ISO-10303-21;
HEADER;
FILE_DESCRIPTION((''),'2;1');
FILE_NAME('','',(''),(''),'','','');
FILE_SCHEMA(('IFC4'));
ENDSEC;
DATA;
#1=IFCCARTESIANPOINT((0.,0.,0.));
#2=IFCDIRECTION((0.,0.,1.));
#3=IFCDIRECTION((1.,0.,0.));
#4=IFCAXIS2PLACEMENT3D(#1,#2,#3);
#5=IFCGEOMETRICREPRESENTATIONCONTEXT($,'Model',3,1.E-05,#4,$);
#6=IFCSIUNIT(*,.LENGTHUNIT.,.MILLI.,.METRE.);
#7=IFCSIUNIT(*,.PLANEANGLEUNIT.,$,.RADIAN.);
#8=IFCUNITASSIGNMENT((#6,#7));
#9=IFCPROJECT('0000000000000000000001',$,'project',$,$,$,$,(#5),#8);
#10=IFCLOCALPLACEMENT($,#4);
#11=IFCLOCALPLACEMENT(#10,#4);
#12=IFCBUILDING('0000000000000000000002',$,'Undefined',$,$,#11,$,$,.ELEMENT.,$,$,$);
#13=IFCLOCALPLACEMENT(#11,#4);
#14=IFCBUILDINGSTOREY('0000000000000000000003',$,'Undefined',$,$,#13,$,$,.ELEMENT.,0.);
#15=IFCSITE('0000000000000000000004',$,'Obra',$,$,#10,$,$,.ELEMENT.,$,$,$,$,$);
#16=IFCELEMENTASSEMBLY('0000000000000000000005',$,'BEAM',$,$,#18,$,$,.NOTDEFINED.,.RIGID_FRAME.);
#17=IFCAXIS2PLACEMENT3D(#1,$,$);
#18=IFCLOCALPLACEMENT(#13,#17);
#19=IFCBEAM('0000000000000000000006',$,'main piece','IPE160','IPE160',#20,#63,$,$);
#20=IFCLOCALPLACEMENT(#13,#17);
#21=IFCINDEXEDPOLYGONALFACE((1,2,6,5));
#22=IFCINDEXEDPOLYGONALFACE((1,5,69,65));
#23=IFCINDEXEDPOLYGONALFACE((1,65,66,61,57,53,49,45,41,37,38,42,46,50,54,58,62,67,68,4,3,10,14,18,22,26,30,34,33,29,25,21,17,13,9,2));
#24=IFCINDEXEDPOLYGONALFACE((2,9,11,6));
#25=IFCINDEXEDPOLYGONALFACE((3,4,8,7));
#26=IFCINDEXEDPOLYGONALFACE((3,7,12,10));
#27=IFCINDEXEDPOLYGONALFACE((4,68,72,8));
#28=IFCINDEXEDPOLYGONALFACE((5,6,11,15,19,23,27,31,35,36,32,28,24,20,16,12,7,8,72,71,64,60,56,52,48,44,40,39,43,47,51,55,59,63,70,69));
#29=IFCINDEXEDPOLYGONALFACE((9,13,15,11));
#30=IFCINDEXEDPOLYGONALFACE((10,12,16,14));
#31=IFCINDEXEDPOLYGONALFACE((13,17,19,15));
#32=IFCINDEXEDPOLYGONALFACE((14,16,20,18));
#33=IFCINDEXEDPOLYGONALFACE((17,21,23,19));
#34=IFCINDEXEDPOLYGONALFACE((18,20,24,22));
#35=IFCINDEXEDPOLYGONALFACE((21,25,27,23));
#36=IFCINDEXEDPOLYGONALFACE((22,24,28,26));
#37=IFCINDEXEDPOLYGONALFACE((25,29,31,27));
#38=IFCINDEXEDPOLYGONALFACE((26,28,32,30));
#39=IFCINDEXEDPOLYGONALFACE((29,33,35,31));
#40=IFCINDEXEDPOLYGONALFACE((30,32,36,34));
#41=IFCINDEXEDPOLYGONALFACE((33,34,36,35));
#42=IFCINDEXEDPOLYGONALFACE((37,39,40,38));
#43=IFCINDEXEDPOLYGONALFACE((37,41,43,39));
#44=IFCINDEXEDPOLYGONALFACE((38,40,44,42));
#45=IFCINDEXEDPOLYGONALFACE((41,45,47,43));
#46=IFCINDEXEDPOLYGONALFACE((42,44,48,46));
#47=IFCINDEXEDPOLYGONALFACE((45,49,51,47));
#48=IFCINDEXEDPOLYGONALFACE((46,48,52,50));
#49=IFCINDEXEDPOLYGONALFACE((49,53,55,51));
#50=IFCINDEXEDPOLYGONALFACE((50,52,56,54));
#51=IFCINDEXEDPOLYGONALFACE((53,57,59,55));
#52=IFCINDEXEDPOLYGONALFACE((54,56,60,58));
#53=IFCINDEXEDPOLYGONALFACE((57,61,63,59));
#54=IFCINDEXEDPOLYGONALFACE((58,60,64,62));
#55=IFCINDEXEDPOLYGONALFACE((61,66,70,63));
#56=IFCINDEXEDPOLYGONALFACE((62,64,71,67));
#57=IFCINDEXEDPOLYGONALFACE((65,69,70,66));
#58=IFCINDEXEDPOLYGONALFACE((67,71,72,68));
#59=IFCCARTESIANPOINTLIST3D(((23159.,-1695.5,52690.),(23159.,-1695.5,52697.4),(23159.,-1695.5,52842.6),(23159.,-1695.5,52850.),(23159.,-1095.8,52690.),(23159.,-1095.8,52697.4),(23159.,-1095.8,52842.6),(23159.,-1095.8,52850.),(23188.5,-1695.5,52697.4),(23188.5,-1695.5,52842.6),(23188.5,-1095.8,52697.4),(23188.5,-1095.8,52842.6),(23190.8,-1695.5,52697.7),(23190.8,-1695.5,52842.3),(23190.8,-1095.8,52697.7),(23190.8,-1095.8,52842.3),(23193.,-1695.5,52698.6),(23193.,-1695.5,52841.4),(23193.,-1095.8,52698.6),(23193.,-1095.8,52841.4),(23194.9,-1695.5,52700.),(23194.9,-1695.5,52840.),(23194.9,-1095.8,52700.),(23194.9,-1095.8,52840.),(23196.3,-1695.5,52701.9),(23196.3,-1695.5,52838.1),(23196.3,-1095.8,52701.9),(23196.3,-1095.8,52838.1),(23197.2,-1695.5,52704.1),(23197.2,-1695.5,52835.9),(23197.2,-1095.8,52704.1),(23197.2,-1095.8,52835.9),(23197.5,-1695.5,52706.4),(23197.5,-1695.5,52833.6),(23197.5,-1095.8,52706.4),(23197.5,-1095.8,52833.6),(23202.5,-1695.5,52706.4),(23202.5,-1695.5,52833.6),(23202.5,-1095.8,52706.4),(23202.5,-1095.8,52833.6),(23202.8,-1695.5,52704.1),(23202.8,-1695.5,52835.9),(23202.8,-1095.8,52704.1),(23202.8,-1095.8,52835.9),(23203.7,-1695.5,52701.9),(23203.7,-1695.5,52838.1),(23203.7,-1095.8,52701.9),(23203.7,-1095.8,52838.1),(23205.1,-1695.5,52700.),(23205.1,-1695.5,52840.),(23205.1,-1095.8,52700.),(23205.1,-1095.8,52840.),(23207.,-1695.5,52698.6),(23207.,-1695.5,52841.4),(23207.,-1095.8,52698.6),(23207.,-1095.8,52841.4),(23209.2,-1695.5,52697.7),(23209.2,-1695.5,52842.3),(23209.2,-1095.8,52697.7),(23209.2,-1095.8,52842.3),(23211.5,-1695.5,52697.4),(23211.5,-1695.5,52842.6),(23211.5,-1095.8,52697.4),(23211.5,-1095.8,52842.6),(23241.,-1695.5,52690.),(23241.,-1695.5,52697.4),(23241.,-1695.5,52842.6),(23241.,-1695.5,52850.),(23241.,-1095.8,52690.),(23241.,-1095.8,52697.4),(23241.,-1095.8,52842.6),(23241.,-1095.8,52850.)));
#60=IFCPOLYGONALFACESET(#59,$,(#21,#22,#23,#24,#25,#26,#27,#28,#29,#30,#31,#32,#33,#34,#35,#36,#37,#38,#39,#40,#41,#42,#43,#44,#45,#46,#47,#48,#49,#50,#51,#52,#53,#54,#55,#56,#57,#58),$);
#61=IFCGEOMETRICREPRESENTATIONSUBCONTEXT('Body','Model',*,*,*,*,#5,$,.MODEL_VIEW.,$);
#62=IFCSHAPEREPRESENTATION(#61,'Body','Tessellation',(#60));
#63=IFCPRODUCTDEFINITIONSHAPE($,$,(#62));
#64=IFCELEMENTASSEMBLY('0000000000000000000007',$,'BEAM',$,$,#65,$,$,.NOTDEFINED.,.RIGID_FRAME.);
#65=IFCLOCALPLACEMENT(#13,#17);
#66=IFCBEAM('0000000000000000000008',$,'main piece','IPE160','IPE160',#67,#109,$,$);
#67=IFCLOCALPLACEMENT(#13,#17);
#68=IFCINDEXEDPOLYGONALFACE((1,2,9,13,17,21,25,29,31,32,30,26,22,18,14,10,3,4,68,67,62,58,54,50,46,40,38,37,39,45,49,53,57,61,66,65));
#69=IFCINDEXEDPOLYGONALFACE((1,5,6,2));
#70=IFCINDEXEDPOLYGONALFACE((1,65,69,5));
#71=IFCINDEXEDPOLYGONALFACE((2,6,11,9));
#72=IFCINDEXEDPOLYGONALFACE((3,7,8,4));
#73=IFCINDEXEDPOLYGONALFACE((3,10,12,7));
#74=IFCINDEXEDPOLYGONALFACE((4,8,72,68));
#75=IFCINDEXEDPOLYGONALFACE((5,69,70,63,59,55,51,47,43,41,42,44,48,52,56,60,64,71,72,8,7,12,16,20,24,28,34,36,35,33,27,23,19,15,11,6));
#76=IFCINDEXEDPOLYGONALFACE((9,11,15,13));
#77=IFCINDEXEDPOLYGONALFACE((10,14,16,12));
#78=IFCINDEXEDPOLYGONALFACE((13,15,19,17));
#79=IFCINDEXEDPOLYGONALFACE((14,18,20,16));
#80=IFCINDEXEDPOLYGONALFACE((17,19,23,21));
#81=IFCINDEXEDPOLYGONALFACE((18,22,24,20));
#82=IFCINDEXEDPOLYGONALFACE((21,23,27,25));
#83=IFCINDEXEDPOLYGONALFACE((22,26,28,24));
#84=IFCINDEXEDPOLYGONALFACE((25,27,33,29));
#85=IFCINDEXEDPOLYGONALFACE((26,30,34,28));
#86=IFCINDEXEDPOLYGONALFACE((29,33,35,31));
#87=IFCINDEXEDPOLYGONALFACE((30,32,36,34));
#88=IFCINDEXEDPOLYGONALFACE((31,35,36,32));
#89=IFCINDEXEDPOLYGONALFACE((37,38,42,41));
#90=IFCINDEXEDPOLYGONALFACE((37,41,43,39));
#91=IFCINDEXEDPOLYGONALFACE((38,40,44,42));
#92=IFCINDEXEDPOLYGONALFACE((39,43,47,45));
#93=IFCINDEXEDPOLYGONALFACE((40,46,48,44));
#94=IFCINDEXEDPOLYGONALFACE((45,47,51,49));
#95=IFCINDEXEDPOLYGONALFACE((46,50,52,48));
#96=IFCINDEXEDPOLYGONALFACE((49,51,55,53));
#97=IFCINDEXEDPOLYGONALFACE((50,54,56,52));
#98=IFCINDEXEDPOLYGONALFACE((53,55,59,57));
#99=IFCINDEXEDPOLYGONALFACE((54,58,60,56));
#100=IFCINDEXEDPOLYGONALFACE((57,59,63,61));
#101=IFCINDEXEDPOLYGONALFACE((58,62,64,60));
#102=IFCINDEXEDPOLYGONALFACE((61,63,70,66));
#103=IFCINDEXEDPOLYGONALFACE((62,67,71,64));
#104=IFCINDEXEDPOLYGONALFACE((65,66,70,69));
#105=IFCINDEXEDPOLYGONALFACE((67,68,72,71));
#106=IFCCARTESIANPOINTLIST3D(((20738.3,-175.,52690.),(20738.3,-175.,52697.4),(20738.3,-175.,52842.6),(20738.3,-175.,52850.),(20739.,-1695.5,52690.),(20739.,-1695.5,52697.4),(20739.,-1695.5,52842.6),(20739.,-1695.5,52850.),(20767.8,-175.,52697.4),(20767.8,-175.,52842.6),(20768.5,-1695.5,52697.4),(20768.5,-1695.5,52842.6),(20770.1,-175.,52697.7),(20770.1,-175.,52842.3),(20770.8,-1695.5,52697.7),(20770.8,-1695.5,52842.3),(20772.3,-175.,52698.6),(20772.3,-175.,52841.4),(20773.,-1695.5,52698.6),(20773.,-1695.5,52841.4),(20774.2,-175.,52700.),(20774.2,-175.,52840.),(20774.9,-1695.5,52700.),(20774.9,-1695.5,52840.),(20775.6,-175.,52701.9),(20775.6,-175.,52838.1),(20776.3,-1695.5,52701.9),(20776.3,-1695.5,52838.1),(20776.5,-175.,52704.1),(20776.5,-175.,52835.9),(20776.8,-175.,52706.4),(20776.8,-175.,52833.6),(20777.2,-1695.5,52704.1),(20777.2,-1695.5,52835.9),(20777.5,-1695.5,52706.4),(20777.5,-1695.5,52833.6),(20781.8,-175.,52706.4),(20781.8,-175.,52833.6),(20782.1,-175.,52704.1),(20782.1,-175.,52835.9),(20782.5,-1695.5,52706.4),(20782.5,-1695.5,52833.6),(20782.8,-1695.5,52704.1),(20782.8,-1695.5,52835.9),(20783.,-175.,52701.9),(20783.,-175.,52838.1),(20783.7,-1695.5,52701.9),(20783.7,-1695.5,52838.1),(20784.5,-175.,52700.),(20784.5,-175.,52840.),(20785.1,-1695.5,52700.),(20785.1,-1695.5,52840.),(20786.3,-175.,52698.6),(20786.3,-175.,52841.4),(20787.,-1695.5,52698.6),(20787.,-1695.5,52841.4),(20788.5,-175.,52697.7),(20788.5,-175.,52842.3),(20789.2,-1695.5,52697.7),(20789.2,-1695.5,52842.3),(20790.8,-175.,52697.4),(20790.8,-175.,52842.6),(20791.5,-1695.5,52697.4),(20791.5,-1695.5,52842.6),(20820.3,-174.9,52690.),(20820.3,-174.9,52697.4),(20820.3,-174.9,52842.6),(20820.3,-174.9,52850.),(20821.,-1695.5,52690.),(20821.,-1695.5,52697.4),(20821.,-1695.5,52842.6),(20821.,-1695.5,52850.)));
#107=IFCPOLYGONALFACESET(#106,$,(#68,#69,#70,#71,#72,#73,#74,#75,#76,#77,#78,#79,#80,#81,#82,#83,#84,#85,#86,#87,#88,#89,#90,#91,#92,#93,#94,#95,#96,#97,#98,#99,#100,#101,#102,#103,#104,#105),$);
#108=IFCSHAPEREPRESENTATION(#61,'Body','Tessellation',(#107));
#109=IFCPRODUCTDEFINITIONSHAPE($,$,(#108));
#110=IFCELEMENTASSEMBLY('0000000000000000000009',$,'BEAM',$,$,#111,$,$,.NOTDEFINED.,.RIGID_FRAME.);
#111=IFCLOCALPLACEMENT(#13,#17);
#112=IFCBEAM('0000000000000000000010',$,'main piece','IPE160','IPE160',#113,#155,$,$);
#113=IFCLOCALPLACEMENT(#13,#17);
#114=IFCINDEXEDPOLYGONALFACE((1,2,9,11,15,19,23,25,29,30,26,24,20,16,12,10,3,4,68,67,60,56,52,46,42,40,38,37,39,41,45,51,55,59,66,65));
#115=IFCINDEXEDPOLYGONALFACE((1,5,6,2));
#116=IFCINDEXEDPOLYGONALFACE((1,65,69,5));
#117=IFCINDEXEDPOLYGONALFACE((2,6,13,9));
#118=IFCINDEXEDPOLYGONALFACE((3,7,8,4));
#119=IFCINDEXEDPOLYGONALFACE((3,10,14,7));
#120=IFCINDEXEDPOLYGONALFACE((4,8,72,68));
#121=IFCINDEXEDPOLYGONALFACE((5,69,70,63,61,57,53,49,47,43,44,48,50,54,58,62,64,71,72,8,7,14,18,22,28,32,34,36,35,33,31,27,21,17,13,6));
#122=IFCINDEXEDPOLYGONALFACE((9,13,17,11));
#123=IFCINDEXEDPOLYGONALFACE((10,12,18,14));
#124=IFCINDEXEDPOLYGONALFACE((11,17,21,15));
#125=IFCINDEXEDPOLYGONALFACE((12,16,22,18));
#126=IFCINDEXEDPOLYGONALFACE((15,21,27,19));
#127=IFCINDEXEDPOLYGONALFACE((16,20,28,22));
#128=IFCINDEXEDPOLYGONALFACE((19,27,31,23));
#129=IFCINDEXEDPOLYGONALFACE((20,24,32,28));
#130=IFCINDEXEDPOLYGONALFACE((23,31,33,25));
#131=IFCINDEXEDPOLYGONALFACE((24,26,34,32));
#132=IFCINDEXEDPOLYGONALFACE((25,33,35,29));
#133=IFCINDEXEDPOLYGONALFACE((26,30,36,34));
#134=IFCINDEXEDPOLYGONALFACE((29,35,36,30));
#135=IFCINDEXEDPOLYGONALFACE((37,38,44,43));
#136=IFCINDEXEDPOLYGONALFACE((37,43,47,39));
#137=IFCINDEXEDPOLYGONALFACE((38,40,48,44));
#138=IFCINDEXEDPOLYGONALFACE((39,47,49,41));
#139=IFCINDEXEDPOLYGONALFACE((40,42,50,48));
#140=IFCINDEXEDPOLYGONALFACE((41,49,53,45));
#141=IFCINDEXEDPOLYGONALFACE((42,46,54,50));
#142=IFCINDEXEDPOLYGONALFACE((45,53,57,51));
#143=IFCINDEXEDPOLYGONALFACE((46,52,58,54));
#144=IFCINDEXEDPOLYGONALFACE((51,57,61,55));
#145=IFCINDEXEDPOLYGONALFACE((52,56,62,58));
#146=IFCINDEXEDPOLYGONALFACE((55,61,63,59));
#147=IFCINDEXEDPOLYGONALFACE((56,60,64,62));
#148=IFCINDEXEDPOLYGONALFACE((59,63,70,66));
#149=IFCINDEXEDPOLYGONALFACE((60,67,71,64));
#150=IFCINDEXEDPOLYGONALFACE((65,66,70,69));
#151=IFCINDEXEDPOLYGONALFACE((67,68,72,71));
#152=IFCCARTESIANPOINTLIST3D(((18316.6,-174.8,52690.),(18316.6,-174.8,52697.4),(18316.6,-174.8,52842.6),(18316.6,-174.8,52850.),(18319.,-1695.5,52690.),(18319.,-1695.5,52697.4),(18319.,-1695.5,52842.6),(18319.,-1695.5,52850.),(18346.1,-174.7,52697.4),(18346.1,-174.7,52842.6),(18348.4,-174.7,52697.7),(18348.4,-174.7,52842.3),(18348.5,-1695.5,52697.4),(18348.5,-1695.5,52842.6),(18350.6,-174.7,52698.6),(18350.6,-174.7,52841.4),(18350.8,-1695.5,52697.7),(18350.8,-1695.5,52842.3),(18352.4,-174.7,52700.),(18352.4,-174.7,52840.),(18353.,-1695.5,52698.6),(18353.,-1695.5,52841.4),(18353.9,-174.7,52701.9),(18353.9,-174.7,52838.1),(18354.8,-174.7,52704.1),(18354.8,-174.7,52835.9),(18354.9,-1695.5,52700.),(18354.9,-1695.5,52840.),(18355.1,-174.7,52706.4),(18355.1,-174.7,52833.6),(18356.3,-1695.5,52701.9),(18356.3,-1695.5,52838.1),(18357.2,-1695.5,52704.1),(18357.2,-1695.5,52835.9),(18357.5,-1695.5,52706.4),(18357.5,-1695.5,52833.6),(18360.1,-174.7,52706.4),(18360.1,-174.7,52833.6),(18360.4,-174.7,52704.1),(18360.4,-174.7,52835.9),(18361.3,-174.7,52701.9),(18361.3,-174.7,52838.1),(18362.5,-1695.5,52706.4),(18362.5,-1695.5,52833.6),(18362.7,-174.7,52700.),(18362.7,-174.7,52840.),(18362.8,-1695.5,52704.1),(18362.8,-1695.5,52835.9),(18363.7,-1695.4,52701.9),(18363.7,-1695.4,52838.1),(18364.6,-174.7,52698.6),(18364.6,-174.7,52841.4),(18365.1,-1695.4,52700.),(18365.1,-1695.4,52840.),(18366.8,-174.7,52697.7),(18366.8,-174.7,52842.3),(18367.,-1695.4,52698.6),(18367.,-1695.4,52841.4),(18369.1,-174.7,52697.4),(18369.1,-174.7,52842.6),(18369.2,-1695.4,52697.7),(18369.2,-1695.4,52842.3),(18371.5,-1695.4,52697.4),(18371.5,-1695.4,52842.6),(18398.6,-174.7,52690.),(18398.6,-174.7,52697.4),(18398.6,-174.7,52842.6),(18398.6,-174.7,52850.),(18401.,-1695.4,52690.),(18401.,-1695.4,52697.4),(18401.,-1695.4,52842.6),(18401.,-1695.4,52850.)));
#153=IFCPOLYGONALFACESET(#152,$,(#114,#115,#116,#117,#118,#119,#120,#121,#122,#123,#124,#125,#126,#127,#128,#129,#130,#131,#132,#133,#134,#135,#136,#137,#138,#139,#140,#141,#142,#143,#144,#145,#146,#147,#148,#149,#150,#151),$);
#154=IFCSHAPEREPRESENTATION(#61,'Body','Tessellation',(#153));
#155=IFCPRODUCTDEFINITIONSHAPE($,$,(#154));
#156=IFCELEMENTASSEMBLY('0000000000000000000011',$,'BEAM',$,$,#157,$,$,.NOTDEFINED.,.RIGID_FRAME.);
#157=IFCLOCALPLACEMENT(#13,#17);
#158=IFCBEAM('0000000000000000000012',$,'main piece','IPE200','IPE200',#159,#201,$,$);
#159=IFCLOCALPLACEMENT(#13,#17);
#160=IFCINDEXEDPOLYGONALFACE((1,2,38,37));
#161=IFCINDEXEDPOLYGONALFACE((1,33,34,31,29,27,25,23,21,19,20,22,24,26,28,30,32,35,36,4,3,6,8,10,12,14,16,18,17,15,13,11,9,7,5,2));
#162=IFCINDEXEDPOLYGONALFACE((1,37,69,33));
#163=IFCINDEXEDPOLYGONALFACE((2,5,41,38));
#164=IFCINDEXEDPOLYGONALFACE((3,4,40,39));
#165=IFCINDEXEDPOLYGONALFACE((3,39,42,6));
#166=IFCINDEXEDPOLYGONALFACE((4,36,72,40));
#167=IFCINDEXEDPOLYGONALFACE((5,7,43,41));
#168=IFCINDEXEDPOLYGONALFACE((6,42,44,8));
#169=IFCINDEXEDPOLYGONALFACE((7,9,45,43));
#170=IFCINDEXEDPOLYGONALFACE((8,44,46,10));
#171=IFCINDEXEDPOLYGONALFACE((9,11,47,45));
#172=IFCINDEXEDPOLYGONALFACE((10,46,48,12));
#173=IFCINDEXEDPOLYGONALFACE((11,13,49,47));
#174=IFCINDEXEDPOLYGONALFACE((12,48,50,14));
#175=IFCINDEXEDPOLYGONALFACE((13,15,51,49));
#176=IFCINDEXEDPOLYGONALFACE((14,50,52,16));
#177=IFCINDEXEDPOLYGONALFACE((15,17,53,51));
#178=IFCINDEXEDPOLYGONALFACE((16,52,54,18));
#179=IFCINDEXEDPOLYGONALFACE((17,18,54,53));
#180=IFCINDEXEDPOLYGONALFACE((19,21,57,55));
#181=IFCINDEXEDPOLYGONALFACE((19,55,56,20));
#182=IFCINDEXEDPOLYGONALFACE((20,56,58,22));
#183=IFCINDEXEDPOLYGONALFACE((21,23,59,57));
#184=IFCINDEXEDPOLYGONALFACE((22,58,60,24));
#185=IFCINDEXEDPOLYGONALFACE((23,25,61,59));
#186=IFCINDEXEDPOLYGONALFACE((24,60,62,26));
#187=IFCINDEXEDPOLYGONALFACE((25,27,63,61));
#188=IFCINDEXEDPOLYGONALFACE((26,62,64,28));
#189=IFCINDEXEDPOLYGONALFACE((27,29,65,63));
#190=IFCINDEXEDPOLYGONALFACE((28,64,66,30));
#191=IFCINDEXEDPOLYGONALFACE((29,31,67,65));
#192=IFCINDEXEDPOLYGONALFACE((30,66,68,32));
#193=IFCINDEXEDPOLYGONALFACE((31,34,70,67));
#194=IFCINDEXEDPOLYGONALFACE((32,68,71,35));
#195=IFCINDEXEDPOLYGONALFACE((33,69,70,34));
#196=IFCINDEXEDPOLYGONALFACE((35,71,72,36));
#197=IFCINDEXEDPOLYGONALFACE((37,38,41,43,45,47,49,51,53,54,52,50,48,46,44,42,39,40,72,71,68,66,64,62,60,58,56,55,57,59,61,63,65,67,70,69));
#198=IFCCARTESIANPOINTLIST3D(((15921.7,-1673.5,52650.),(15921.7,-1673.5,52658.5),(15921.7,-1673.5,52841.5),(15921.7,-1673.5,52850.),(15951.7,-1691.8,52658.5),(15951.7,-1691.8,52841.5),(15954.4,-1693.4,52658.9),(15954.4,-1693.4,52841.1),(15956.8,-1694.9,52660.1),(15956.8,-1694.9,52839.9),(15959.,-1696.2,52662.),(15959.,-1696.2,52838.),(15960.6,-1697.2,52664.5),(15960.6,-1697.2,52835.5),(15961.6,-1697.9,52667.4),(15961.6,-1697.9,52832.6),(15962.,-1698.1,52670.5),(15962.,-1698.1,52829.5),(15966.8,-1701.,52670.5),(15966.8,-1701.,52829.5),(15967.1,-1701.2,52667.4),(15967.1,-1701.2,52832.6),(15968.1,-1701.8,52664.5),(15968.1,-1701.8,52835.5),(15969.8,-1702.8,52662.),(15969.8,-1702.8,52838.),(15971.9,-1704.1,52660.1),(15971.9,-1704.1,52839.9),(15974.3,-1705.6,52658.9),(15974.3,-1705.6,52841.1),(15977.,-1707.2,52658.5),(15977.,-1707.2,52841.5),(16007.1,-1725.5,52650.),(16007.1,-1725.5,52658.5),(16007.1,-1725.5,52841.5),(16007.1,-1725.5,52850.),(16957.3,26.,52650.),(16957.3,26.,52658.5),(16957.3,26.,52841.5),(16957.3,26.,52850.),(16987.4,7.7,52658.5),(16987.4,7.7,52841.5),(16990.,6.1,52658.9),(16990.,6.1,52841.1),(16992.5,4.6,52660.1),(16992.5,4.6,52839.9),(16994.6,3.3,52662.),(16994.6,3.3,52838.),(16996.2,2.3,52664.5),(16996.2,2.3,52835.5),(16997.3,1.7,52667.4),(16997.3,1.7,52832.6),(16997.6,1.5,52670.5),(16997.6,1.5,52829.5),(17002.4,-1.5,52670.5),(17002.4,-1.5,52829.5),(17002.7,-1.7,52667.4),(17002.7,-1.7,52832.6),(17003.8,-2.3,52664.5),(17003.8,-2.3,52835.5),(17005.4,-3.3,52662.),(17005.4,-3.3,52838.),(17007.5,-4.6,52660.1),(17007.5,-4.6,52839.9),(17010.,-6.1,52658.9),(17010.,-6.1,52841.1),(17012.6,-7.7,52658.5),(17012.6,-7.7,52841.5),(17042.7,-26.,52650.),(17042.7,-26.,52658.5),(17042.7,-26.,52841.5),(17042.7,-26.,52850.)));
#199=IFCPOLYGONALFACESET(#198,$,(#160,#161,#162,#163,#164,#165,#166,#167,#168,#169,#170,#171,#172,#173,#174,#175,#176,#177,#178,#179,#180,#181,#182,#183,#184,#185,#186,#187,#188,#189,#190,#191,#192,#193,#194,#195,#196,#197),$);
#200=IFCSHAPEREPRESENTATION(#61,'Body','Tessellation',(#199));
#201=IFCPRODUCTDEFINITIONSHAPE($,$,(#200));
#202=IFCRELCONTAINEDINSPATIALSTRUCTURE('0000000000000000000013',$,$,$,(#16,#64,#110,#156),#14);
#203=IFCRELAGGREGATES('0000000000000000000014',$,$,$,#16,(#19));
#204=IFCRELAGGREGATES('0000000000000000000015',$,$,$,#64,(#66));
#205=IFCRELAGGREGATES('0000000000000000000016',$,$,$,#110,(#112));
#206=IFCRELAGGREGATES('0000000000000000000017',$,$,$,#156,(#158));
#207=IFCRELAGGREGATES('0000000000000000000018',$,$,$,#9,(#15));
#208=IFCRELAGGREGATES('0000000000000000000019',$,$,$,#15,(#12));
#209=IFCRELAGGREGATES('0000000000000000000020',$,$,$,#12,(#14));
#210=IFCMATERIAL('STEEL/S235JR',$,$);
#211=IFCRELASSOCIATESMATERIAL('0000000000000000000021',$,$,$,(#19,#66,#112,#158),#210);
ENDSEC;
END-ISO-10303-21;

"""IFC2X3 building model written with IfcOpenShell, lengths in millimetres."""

from ifc_helpers import new_model, si_unit, frame, origin_with_axes, origin_2d_with_axis, place, context, subcontext, project, spatial, i_section, extrude, material, element, aggregate, save


model = new_model("IFC2X3")

# Units and contexts
model_context = context("Model", 3, precision=1e-05, world=origin_with_axes())
body_context = subcontext(model_context, "Body", "Model", "MODEL_VIEW")
ifc_project = project(units=[si_unit("LENGTHUNIT", "METRE", prefix="MILLI"), si_unit("PLANEANGLEUNIT", "RADIAN")], contexts=[model_context])

# Site, building, storey
site_placement = place(None, origin_with_axes())
site = spatial("IfcSite", under=ifc_project, at=site_placement, Name="Obra", CompositionType="ELEMENT")
building_placement = place(site_placement, origin_with_axes())
building = spatial("IfcBuilding", under=site, at=building_placement, Name="Undefined", CompositionType="ELEMENT")
storey_placement = place(building_placement, origin_with_axes())
storey = spatial("IfcBuildingStorey", under=building, at=storey_placement, Name="Undefined", CompositionType="ELEMENT", Elevation=0.0)

# Shared definitions
ifc_material_1 = material(Name="STEEL/S235JR")

# Element assemblies, beams
assembly_1_placement = place(storey_placement, origin_with_axes())
assembly_1 = element("IfcElementAssembly", 1, at=assembly_1_placement, inside=storey, Name="BEAM", AssemblyPlace="NOTDEFINED", PredefinedType="RIGID_FRAME")
beam_1_placement = place(assembly_1_placement, frame((23200.0, -1695.5, 52770.0), z_axis=(0.0, 0.0, 1.0), x_axis=(0.0, 1.0, 0.0)))
beam_1 = element("IfcBeam", 2, at=beam_1_placement, material=ifc_material_1, Name="main piece", Description="IPE160", ObjectType="IPE160", context=body_context, shape_type="SweptSolid", body=[
    extrude(i_section(OverallWidth=82.0, OverallDepth=160.0, WebThickness=5.0, FlangeThickness=7.4, FilletRadius=9.0, at=origin_2d_with_axis()), frame((599.7, 0.0, 0.0), z_axis=(-1.0, 0.0, 0.0), x_axis=(0.0, -1.0, 0.0)), (0.0, 0.0, 1.0), 599.7),
])
aggregate(assembly_1, [beam_1])
assembly_2_placement = place(storey_placement, origin_with_axes())
assembly_2 = element("IfcElementAssembly", 3, at=assembly_2_placement, inside=storey, Name="BEAM", AssemblyPlace="NOTDEFINED", PredefinedType="RIGID_FRAME")
beam_2_placement = place(assembly_2_placement, frame((20779.3, -175.0, 52770.0), z_axis=(0.0, 0.0, 1.0), x_axis=(0.00045, -1.0, 0.0)))
beam_2 = element("IfcBeam", 4, at=beam_2_placement, material=ifc_material_1, Name="main piece", Description="IPE160", ObjectType="IPE160", context=body_context, shape_type="SweptSolid", body=[
    extrude(i_section(OverallWidth=82.0, OverallDepth=160.0, WebThickness=5.0, FlangeThickness=7.4, FilletRadius=9.0, at=origin_2d_with_axis()), frame((1520.5, 0.0, 0.0), z_axis=(-1.0, 0.0, 0.0), x_axis=(0.0, -1.0, 0.0)), (0.0, 0.0, 1.0), 1520.5),
])
aggregate(assembly_2, [beam_2])
assembly_3_placement = place(storey_placement, origin_with_axes())
assembly_3 = element("IfcElementAssembly", 5, at=assembly_3_placement, inside=storey, Name="BEAM", AssemblyPlace="NOTDEFINED", PredefinedType="RIGID_FRAME")
beam_3_placement = place(assembly_3_placement, frame((18360.0, -1695.5, 52770.0), z_axis=(0.0, 0.0, 1.0), x_axis=(-0.001588, 0.999999, 0.0)))
beam_3 = element("IfcBeam", 6, at=beam_3_placement, material=ifc_material_1, Name="main piece", Description="IPE160", ObjectType="IPE160", context=body_context, shape_type="SweptSolid", body=[
    extrude(i_section(OverallWidth=82.0, OverallDepth=160.0, WebThickness=5.0, FlangeThickness=7.4, FilletRadius=9.0, at=origin_2d_with_axis()), frame((1520.7, 0.0, 0.0), z_axis=(-1.0, 0.0, 0.0), x_axis=(0.0, -1.0, 0.0)), (0.0, 0.0, 1.0), 1520.7),
])
aggregate(assembly_3, [beam_3])
assembly_4_placement = place(storey_placement, origin_with_axes())
assembly_4 = element("IfcElementAssembly", 7, at=assembly_4_placement, inside=storey, Name="BEAM", AssemblyPlace="NOTDEFINED", PredefinedType="RIGID_FRAME")
beam_4_placement = place(assembly_4_placement, frame((17000.0, 0.0, 52750.0), z_axis=(0.0, 0.0, 1.0), x_axis=(-0.520368, -0.853942, 0.0)))
beam_4 = element("IfcBeam", 8, at=beam_4_placement, material=ifc_material_1, Name="main piece", Description="IPE200", ObjectType="IPE200", context=body_context, shape_type="SweptSolid", body=[
    extrude(i_section(OverallWidth=100.0, OverallDepth=200.0, WebThickness=5.6, FlangeThickness=8.5, FilletRadius=12.0, at=origin_2d_with_axis()), frame((1990.2, 0.0, 0.0), z_axis=(-1.0, 0.0, 0.0), x_axis=(0.0, -1.0, 0.0)), (0.0, 0.0, 1.0), 1990.2),
])
aggregate(assembly_4, [beam_4])

save(model, "model.ifc")
